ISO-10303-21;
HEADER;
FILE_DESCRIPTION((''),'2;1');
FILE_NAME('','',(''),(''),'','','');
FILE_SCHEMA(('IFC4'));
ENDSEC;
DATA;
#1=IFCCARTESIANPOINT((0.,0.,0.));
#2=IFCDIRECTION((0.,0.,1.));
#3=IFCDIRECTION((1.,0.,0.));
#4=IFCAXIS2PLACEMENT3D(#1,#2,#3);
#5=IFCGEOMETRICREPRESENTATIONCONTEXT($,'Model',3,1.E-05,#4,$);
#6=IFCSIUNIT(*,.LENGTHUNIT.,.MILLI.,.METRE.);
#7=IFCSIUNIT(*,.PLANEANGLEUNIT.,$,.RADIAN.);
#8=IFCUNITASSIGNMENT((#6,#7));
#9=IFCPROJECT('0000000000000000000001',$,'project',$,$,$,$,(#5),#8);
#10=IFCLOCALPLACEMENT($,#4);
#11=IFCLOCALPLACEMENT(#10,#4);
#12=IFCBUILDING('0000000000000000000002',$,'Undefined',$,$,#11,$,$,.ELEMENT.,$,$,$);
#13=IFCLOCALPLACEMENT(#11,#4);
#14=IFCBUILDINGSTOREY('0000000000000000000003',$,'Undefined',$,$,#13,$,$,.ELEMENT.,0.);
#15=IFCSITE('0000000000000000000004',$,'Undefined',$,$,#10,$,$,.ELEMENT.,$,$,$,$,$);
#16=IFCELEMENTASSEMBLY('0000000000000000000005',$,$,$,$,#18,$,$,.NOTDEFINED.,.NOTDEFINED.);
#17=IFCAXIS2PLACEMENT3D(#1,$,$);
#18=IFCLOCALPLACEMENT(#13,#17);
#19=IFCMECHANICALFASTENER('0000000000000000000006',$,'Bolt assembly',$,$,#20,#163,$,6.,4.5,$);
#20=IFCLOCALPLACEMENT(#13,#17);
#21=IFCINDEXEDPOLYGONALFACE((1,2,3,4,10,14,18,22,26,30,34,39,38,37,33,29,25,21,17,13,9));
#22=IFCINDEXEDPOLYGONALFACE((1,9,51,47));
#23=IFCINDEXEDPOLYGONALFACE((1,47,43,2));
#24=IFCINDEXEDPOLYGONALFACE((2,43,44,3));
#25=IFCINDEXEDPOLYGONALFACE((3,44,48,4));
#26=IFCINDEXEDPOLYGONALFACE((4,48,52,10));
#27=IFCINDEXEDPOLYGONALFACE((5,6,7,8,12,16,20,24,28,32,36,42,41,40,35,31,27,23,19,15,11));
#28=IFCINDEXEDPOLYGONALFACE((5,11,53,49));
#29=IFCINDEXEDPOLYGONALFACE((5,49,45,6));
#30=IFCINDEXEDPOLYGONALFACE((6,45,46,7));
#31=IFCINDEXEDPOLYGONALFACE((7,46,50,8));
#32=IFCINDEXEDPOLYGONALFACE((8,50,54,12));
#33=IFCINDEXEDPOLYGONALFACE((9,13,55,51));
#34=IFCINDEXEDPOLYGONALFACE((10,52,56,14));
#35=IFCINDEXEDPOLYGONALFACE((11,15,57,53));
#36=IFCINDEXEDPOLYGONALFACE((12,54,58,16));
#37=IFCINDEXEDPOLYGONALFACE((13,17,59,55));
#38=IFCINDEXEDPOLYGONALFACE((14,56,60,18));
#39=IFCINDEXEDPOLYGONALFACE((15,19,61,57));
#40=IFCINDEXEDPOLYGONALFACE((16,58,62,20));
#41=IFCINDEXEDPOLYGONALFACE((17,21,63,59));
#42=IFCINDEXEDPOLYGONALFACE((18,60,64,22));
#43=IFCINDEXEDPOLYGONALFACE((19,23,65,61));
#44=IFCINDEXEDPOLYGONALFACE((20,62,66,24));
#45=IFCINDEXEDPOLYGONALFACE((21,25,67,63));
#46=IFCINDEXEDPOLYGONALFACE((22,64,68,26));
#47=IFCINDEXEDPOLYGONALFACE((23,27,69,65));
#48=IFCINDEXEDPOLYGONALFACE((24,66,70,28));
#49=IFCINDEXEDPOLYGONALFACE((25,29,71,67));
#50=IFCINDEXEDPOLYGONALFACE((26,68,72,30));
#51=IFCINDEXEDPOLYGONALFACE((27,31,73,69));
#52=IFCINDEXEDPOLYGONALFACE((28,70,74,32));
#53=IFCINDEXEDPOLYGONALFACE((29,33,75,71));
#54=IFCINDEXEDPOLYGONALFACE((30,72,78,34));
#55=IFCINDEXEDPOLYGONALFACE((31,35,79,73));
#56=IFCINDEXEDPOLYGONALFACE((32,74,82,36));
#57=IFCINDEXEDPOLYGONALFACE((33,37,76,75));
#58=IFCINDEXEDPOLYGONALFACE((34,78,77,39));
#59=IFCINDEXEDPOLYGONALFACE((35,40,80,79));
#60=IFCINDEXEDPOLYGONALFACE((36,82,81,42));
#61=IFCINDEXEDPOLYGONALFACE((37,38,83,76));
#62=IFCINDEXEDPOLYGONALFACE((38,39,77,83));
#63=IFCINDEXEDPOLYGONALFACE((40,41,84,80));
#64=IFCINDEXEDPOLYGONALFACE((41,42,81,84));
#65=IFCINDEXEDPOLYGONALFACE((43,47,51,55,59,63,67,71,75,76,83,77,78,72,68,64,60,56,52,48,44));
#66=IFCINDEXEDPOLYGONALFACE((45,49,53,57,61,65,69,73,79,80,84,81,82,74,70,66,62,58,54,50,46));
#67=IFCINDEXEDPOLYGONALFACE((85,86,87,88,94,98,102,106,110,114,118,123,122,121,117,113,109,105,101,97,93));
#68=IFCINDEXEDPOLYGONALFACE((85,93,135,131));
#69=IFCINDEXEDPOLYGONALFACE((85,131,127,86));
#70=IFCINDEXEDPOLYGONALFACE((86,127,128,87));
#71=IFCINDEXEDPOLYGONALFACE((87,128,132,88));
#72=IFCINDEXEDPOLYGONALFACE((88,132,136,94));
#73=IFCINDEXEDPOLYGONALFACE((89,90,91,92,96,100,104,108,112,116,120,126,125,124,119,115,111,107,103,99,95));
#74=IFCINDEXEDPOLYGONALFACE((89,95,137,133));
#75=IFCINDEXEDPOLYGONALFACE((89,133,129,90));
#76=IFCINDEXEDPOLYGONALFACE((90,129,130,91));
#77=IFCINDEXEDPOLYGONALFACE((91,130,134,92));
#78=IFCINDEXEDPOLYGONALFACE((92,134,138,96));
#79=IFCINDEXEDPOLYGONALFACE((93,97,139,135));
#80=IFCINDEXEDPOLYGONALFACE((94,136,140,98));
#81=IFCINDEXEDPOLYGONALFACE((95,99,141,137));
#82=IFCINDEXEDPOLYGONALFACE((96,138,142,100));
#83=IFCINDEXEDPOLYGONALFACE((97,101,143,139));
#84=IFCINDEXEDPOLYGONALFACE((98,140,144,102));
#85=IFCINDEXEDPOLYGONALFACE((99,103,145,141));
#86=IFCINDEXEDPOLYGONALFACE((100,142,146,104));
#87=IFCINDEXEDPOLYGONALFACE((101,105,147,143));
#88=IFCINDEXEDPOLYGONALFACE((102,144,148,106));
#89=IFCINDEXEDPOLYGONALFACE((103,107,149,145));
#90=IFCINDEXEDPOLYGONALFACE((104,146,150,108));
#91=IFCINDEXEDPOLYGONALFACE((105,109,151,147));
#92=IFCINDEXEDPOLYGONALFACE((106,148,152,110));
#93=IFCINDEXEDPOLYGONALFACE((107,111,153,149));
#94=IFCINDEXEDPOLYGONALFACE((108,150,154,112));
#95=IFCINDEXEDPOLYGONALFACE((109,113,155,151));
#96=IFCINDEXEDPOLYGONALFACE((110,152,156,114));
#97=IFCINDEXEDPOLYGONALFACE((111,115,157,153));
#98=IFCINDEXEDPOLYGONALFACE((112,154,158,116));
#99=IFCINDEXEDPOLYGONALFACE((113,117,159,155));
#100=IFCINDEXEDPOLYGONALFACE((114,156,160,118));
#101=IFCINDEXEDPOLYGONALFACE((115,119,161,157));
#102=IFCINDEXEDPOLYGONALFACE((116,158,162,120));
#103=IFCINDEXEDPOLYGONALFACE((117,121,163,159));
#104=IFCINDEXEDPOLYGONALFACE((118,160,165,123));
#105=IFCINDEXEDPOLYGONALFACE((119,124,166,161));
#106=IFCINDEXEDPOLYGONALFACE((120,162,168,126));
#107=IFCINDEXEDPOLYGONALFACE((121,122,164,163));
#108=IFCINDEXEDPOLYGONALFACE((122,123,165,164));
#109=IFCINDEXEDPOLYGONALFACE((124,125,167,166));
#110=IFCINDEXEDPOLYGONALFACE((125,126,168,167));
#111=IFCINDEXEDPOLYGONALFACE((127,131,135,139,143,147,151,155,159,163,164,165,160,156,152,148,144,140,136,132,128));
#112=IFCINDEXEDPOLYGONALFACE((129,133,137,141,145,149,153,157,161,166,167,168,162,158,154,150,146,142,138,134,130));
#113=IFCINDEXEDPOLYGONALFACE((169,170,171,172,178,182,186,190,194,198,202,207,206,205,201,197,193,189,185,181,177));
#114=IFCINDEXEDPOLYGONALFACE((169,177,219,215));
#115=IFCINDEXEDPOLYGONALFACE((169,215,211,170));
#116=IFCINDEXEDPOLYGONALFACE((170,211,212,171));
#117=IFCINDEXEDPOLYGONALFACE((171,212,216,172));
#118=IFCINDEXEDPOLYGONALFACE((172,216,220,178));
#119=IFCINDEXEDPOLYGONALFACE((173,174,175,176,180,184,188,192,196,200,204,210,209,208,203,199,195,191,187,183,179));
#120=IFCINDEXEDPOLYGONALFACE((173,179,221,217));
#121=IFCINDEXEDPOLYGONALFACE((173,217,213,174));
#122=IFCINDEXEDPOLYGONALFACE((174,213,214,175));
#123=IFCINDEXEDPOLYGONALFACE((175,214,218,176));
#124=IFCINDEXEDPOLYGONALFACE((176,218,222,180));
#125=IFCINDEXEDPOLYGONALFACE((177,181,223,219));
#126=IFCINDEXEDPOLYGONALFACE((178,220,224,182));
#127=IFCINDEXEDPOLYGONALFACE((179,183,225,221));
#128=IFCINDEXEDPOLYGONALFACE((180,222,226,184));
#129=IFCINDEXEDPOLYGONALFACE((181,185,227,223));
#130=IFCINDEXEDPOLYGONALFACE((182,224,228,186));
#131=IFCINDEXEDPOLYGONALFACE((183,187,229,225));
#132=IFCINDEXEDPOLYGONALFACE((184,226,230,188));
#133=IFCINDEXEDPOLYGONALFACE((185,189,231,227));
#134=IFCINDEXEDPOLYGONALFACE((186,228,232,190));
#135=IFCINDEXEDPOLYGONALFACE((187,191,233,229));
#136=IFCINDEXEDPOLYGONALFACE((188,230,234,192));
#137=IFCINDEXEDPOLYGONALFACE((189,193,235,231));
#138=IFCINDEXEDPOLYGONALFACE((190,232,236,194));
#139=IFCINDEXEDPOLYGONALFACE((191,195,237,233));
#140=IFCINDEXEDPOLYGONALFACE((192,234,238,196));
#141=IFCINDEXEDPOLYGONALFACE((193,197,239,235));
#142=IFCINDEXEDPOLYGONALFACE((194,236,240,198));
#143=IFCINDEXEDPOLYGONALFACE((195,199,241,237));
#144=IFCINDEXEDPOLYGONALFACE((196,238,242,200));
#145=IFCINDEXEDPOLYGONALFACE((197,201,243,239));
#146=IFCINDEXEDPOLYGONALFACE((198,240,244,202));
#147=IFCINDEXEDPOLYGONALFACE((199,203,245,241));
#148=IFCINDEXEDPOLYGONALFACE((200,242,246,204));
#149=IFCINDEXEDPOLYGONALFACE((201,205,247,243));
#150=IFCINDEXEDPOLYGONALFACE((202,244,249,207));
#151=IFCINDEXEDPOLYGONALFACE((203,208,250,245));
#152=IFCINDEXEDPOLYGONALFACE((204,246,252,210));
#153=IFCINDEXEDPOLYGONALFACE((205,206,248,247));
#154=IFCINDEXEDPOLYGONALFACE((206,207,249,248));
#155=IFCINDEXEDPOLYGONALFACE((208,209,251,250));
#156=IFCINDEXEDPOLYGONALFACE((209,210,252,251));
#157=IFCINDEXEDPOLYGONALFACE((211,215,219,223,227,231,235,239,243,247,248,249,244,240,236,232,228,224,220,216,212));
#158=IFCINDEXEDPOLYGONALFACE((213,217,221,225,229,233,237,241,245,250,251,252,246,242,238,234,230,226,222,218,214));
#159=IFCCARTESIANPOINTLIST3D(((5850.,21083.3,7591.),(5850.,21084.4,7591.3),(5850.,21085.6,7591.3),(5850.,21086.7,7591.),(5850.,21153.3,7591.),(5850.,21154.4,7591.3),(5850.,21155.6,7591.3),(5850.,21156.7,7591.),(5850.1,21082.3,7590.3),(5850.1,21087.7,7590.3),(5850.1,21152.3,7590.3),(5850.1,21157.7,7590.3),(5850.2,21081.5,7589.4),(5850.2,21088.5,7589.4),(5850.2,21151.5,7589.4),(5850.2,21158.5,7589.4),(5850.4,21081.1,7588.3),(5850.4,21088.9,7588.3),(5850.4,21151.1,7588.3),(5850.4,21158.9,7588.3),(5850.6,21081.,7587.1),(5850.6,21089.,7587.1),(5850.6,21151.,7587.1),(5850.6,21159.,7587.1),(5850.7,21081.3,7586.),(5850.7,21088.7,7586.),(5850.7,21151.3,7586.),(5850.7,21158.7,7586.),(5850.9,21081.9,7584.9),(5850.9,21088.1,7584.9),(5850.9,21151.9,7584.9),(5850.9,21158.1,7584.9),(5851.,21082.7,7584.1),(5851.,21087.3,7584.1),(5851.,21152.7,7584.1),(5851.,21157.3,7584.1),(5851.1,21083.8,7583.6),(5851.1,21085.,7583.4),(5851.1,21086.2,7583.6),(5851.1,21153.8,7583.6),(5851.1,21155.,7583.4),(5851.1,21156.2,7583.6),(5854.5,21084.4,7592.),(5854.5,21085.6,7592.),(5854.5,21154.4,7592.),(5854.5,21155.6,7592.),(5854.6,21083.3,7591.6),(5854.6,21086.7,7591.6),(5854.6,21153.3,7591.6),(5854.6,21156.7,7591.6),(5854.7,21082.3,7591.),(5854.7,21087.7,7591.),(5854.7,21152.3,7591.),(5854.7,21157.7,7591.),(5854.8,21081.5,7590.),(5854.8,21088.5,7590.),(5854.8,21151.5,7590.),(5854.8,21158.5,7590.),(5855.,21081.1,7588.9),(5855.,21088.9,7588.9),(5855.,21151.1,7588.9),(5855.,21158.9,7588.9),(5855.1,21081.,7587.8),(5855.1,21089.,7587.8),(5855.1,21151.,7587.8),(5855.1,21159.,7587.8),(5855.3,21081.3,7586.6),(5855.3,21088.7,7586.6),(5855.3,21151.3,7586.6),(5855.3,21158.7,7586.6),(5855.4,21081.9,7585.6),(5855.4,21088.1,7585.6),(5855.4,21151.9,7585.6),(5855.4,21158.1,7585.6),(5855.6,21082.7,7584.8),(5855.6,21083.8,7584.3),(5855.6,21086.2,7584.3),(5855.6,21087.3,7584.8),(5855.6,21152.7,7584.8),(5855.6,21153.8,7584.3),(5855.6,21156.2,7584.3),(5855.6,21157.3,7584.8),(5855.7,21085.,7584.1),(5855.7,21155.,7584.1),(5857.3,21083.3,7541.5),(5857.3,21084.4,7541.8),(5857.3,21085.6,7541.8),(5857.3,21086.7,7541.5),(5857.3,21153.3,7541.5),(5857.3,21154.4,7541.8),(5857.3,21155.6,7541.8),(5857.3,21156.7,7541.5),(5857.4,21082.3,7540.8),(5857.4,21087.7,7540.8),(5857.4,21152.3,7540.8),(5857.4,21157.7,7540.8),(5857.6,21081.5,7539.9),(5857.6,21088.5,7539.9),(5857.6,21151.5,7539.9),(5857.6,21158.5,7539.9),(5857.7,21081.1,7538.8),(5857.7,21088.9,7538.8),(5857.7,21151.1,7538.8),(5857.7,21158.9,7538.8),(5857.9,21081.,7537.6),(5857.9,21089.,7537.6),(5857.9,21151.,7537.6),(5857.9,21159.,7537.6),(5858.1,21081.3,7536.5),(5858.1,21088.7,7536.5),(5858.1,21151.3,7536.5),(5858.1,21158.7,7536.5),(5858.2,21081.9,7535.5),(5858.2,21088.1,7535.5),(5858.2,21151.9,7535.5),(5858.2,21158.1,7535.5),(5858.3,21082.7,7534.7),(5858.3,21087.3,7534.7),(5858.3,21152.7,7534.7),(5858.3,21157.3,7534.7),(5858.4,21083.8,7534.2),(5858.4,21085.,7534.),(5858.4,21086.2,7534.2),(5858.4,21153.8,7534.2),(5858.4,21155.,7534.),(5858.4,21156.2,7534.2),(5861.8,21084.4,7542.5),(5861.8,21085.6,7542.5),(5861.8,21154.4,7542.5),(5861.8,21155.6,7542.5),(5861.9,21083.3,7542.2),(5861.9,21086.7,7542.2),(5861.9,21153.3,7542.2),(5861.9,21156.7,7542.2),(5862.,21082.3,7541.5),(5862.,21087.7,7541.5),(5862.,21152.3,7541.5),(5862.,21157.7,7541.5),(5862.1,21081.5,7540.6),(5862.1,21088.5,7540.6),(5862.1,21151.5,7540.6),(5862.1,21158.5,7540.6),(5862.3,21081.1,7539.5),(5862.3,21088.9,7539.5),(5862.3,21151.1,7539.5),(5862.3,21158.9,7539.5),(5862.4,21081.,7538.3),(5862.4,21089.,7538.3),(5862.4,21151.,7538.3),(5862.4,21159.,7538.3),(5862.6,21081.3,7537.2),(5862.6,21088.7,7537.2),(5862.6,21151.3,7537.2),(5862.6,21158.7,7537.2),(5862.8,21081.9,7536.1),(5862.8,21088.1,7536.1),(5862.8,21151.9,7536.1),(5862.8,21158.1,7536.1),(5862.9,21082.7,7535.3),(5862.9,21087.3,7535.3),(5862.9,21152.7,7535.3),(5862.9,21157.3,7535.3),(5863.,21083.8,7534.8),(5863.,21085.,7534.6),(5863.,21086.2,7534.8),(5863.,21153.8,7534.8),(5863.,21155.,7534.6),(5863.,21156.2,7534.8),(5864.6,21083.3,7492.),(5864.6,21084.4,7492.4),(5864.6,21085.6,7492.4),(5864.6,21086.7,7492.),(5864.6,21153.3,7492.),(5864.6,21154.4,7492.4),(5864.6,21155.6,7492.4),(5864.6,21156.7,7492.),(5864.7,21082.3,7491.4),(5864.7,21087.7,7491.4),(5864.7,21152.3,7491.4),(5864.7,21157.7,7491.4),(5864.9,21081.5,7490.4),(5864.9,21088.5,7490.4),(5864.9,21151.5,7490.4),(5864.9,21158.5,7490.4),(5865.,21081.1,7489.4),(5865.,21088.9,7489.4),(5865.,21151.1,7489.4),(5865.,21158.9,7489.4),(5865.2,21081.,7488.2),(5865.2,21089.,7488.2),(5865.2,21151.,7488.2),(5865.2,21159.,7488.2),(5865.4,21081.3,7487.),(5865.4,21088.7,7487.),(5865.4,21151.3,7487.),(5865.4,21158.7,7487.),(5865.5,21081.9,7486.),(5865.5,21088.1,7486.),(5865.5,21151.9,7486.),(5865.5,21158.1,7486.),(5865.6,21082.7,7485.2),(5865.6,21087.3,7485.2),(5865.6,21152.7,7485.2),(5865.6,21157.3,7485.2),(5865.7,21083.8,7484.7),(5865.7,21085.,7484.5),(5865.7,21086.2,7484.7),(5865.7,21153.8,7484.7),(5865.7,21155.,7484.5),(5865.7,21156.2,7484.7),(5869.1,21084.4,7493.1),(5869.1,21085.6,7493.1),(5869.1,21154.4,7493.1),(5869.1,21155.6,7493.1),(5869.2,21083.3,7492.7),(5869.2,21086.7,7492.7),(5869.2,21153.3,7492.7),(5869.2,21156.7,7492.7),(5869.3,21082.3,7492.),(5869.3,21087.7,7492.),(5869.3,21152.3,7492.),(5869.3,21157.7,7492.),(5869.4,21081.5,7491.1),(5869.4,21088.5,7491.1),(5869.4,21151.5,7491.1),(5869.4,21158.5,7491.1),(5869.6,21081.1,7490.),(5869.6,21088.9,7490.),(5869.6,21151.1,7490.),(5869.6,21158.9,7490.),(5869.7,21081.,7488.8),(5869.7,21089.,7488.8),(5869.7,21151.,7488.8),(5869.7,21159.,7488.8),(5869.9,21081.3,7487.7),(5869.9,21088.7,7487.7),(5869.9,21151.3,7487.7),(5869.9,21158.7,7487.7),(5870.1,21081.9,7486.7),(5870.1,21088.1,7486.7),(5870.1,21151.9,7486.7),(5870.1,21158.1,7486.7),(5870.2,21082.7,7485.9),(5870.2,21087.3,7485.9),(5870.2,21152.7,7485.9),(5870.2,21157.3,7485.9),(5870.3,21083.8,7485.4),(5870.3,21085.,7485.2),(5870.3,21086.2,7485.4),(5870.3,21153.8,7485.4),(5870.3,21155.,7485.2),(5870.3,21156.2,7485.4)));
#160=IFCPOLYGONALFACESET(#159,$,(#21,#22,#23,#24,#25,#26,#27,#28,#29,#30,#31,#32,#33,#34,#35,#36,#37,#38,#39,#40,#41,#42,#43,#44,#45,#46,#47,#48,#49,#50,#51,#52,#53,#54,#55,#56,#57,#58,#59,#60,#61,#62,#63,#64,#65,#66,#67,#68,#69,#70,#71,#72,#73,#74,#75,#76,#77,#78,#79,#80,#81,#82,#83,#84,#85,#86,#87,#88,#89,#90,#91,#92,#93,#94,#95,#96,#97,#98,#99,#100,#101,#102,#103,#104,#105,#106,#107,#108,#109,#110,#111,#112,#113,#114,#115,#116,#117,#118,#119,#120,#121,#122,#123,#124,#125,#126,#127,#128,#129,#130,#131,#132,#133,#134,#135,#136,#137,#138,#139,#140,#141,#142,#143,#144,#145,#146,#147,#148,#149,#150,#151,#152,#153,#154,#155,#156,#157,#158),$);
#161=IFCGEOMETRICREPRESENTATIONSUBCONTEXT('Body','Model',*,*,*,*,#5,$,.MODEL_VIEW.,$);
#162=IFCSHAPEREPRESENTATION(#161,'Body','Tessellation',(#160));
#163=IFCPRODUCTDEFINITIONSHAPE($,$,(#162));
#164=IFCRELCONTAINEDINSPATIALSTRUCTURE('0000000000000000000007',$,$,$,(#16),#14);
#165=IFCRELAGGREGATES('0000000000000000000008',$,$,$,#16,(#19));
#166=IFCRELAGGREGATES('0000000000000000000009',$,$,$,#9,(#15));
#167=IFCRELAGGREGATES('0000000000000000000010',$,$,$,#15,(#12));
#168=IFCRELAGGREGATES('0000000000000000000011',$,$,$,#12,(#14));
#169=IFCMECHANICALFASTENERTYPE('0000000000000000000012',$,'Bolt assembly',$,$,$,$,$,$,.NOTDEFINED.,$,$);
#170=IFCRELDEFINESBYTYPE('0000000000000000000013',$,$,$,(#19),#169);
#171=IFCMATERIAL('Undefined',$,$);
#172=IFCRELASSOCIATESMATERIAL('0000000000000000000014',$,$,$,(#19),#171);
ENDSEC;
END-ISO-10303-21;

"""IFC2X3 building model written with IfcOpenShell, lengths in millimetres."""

from ifc_helpers import new_model, si_unit, frame, origin_with_axes, origin_2d_with_axis, place, context, subcontext, project, spatial, circle, extrude, source, transform, mapped, material, type_object, element, aggregate, save


model = new_model("IFC2X3")

# Units and contexts
model_context = context("Model", 3, precision=1e-05, world=origin_with_axes())
body_context = subcontext(model_context, "Body", "Model", "MODEL_VIEW")
ifc_project = project(units=[si_unit("LENGTHUNIT", "METRE", prefix="MILLI"), si_unit("PLANEANGLEUNIT", "RADIAN")], contexts=[model_context])

# Site, building, storey
site_placement = place(None, origin_with_axes())
site = spatial("IfcSite", under=ifc_project, at=site_placement, Name="Undefined", CompositionType="ELEMENT")
building_placement = place(site_placement, origin_with_axes())
building = spatial("IfcBuilding", under=site, at=building_placement, Name="Undefined", CompositionType="ELEMENT")
storey_placement = place(building_placement, origin_with_axes())
storey = spatial("IfcBuildingStorey", under=building, at=storey_placement, Name="Undefined", CompositionType="ELEMENT", Elevation=0.0)

# Element assembly
assembly_1_placement = place(storey_placement, origin_with_axes())
assembly_1 = element("IfcElementAssembly", 1, at=assembly_1_placement, inside=storey, AssemblyPlace="NOTDEFINED", PredefinedType="NOTDEFINED")

# Mechanical fastener
ifc_material_1 = material(Name="Undefined")
mechanical_fastener_type = type_object("IfcMechanicalFastenerType", Name="Bolt assembly")
shared_shape_1 = source(origin_with_axes(), body_context, "Body", "SweptSolid", [
    extrude(circle(Radius=4.0, at=origin_2d_with_axis()), frame((0.0, 0.0, 0.0), z_axis=(0.0, 1.0, 0.0), x_axis=(1.0, 0.0, 0.0)), (0.0, 0.0, 1.0), 4.6),
])
mechanical_fastener_1_placement = place(assembly_1_placement, frame((5850.5, 21120.0, 7587.4), z_axis=(0.0, -1.0, 0.0), x_axis=(0.146203, 0.0, -0.989255)))
mechanical_fastener_1 = element("IfcMechanicalFastener", 2, at=mechanical_fastener_1_placement, type_object=mechanical_fastener_type, material=ifc_material_1, Name="Bolt assembly", NominalDiameter=6.0, NominalLength=4.5, context=body_context, shape_type="MappedRepresentation", body=[
    mapped(shared_shape_1, transform((0.0, 0.0, -35.0))),
    mapped(shared_shape_1, transform((50.0, 0.0, -35.0))),
    mapped(shared_shape_1, transform((100.0, 0.0, -35.0))),
    mapped(shared_shape_1, transform((0.0, 0.0, 35.0))),
    mapped(shared_shape_1, transform((50.0, 0.0, 35.0))),
    mapped(shared_shape_1, transform((100.0, 0.0, 35.0))),
])

aggregate(assembly_1, [mechanical_fastener_1])

save(model, "model.ifc")
